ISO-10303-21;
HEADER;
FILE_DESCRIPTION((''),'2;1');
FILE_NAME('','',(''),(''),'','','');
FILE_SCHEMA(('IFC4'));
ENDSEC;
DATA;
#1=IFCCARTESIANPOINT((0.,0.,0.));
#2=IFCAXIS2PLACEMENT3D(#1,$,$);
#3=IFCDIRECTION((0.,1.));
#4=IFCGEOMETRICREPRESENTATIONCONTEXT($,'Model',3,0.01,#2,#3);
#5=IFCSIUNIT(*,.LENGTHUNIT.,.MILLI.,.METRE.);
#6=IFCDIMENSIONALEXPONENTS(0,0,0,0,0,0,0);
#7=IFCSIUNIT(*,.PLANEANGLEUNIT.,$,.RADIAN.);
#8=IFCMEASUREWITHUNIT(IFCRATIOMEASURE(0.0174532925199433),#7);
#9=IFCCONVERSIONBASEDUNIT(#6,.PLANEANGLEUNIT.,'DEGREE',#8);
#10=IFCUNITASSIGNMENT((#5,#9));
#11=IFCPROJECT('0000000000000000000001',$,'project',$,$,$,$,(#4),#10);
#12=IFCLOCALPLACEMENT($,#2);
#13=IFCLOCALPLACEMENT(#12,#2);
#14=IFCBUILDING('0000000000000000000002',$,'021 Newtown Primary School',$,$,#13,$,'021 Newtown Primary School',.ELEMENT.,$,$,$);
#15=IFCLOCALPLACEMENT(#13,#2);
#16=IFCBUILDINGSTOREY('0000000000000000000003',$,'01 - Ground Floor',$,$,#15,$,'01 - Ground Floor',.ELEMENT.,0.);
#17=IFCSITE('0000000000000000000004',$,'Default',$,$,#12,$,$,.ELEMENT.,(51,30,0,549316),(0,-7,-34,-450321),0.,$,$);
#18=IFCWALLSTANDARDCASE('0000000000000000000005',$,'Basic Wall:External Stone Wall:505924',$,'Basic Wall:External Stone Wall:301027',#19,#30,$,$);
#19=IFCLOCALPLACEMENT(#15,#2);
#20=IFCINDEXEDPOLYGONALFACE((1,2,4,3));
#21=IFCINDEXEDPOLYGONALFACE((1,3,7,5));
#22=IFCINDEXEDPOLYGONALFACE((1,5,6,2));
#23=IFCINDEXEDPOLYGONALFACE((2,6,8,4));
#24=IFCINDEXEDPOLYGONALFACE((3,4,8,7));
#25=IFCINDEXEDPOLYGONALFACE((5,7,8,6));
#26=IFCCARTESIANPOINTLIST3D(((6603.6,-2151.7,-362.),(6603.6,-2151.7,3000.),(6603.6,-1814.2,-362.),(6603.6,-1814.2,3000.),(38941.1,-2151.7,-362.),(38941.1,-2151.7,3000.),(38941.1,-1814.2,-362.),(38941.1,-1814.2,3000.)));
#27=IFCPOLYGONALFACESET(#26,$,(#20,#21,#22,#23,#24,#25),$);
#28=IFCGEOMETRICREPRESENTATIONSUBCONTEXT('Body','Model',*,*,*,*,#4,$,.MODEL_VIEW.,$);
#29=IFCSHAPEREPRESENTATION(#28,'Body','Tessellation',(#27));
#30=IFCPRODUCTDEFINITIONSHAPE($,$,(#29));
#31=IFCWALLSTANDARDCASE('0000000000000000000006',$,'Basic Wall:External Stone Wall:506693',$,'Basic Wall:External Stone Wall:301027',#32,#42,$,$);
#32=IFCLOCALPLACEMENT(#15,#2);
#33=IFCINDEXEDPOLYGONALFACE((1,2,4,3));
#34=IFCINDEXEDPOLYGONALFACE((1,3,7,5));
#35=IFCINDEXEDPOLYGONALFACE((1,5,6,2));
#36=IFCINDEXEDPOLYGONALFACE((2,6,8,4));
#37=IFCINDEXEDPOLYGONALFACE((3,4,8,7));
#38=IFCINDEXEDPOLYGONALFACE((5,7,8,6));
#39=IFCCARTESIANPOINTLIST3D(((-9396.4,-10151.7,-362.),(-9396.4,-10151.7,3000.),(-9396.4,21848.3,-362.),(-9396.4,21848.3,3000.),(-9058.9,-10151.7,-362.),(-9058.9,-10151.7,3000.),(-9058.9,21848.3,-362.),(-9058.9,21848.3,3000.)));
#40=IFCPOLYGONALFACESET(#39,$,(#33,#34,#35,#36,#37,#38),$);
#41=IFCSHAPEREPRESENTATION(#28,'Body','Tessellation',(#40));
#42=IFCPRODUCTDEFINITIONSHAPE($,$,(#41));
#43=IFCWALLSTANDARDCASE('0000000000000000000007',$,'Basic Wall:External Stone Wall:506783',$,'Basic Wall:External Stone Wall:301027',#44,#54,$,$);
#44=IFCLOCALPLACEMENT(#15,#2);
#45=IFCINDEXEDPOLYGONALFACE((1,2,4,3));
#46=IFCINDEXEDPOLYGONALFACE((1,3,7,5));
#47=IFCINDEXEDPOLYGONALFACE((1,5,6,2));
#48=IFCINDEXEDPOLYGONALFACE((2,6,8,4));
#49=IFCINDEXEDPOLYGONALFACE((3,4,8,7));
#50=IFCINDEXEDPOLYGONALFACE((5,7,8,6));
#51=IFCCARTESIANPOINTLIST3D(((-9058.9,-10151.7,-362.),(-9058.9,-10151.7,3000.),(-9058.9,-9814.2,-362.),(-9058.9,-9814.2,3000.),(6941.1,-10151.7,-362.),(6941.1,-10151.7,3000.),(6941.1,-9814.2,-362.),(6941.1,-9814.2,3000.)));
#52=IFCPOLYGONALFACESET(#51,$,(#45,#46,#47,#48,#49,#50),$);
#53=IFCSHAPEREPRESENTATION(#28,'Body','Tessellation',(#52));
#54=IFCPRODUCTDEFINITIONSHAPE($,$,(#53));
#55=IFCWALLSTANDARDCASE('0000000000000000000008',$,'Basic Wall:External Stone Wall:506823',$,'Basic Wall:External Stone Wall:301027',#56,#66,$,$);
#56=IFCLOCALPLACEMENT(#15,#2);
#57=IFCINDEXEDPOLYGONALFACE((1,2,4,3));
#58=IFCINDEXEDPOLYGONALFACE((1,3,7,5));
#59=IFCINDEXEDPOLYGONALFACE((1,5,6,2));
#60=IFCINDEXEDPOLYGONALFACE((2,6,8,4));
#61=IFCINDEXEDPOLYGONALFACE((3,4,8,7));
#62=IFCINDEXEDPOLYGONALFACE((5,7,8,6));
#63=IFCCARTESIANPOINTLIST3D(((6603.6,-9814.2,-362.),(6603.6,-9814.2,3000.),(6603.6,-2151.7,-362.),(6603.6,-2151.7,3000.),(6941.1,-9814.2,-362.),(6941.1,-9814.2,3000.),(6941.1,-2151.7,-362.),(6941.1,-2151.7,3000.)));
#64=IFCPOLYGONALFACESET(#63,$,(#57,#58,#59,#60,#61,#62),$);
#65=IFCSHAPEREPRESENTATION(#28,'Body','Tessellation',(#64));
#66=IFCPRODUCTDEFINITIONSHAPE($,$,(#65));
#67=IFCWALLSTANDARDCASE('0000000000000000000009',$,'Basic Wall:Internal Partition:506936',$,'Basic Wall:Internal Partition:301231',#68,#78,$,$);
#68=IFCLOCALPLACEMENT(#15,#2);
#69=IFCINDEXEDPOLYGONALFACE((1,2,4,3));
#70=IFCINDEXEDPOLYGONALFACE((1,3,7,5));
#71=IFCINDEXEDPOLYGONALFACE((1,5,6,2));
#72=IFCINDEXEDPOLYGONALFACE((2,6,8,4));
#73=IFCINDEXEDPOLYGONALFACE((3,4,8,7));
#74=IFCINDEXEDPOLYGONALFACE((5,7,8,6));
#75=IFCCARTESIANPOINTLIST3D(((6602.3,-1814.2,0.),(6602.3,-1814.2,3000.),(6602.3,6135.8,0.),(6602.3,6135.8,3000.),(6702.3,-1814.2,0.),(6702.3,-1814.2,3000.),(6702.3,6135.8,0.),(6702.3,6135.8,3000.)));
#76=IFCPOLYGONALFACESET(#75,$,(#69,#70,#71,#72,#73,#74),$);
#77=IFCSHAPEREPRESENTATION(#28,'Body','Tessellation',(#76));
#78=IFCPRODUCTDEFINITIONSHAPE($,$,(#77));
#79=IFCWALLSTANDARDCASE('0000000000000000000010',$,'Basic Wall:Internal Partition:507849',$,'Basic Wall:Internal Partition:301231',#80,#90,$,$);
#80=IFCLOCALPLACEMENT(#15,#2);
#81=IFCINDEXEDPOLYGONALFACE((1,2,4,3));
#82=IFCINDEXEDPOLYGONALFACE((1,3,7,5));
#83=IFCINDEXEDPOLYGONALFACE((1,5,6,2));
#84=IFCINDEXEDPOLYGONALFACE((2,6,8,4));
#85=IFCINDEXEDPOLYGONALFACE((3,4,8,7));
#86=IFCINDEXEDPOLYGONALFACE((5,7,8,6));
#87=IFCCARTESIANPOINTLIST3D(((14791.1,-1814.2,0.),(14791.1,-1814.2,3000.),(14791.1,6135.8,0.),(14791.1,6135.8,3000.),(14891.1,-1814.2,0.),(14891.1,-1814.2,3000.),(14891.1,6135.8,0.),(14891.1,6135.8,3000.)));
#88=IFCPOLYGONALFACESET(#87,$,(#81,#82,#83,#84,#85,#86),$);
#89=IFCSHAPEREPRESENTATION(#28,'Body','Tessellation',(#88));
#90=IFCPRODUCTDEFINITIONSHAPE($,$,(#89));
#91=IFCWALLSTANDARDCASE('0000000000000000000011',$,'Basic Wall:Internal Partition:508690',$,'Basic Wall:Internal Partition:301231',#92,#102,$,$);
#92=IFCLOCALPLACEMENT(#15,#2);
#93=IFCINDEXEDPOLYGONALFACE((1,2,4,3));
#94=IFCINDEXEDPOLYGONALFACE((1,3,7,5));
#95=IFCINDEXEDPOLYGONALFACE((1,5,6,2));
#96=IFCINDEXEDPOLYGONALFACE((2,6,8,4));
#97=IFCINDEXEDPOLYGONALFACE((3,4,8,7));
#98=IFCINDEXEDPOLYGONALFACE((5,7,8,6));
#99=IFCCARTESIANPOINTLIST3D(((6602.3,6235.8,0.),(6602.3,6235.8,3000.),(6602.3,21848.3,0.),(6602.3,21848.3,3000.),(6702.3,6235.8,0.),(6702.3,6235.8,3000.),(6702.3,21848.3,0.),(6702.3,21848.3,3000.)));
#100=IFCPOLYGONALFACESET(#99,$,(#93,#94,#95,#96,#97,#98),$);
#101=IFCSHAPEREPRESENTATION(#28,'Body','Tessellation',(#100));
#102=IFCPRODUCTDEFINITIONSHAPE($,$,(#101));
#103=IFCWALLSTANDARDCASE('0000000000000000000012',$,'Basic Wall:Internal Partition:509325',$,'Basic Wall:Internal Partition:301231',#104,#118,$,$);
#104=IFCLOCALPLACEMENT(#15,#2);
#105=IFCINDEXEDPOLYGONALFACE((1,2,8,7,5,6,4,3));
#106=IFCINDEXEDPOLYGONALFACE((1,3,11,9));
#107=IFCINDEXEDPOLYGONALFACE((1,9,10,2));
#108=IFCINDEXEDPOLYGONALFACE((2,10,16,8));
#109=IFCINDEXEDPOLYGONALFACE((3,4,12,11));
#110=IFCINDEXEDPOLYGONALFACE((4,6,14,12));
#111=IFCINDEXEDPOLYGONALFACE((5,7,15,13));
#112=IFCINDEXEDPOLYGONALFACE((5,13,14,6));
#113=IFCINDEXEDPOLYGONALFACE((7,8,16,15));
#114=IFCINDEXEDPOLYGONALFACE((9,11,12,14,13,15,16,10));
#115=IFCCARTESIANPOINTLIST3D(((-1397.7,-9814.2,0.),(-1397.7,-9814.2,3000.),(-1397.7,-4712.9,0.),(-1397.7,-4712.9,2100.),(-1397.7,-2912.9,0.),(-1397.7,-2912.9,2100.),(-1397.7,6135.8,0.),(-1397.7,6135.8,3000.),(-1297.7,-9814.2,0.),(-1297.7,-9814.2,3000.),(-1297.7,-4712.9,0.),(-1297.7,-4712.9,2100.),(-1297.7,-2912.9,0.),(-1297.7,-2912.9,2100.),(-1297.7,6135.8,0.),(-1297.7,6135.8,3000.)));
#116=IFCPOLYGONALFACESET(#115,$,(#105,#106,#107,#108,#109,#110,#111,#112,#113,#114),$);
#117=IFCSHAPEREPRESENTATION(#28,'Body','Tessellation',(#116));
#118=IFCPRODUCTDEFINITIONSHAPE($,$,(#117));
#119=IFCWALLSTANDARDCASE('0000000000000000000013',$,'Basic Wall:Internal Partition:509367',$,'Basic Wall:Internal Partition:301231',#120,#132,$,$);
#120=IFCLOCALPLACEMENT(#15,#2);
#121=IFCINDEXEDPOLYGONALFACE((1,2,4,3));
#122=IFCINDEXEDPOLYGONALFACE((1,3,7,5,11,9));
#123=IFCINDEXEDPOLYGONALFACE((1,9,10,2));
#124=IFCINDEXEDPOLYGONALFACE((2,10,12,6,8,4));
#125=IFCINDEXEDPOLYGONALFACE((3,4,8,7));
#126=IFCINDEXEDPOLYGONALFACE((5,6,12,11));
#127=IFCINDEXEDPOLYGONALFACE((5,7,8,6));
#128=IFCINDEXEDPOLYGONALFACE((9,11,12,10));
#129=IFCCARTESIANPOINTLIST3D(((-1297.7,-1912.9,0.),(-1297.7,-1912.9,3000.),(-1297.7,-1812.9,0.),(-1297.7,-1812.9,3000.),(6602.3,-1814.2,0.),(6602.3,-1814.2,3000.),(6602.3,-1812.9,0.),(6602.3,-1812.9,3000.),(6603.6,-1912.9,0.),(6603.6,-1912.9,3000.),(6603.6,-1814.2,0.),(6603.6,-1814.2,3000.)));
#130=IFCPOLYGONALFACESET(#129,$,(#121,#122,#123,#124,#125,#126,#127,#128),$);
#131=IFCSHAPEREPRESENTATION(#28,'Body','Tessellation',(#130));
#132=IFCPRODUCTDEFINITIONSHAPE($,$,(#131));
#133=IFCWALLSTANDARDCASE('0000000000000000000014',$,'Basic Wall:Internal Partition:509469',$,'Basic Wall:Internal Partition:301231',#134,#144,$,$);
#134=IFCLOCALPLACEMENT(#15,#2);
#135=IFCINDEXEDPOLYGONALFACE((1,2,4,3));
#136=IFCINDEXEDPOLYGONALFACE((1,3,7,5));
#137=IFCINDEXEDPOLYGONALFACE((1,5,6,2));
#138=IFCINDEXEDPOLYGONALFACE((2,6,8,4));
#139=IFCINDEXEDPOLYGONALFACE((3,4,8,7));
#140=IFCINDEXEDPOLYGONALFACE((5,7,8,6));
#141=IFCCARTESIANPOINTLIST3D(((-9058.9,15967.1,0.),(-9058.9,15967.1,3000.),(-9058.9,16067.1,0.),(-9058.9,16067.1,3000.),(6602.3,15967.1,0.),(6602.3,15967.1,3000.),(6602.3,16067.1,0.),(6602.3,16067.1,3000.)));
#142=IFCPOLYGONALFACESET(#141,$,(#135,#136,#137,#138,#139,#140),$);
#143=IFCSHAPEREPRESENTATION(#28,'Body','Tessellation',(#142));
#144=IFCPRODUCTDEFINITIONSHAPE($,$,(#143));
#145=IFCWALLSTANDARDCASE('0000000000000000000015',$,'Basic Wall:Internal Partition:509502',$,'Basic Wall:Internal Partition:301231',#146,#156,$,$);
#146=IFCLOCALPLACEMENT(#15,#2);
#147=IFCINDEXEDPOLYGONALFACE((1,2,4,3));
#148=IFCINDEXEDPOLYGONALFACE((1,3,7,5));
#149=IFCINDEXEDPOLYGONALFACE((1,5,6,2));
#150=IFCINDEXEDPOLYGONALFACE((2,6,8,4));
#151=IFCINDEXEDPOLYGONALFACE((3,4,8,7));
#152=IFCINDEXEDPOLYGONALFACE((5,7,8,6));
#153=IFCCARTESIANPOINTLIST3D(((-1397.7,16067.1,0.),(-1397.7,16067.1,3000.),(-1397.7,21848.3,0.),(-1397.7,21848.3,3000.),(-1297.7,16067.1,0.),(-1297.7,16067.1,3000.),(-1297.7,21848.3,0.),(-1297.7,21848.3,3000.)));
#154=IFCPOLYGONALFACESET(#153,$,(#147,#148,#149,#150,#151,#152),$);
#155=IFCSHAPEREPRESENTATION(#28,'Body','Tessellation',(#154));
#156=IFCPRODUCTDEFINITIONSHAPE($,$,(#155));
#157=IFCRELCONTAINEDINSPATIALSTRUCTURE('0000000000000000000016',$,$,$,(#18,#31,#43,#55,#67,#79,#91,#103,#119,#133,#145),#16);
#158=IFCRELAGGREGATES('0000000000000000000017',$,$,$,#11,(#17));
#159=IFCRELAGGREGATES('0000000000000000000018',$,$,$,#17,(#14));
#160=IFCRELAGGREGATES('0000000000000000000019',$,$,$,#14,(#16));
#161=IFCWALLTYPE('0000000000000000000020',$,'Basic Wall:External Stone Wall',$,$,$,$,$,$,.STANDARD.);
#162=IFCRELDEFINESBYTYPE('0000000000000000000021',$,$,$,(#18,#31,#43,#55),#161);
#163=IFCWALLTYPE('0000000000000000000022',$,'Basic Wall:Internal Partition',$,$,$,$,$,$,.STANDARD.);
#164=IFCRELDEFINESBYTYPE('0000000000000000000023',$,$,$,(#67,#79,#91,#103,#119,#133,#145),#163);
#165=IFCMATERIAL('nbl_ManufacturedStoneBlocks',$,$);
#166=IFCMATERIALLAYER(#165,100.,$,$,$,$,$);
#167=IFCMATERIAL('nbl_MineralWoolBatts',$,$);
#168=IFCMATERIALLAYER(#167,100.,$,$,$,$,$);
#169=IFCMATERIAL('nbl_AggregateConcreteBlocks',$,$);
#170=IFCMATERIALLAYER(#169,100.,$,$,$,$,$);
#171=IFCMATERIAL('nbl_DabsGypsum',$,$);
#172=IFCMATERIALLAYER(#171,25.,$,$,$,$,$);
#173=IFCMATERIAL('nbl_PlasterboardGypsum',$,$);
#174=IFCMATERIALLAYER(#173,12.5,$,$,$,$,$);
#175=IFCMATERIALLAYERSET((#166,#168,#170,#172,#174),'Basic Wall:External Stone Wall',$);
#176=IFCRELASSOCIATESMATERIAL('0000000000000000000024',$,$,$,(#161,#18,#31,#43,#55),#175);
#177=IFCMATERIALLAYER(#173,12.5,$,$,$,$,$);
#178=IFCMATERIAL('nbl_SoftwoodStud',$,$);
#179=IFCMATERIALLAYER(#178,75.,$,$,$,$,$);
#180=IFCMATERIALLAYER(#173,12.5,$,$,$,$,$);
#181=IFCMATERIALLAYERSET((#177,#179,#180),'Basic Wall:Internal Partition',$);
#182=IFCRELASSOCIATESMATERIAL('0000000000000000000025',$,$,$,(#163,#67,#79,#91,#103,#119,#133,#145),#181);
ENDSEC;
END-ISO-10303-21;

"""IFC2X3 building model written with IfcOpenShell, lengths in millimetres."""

from ifc_helpers import new_model, entity, si_unit, converted_unit, direction, frame, frame_2d, origin, place, context, subcontext, project, spatial, polyline, rectangle, outline, extrude, material, layer, layer_set, layer_usage, type_object, element, save


model = new_model("IFC2X3")

# Units and contexts
model_context = context("Model", 3, precision=0.01, world=origin(), true_north=direction((0.0, 1.0)))
body_context = subcontext(model_context, "Body", "Model", "MODEL_VIEW")
ifc_project = project(units=[si_unit("LENGTHUNIT", "METRE", prefix="MILLI"), converted_unit("PLANEANGLEUNIT", "DEGREE", entity("IfcRatioMeasure", 0.0174532925199433), si_unit("PLANEANGLEUNIT", "RADIAN"), dimensions=[0, 0, 0, 0, 0, 0, 0])], contexts=[model_context])

# Site, building, storey
site_placement = place(None, origin())
site = spatial("IfcSite", under=ifc_project, at=site_placement, Name="Default", CompositionType="ELEMENT", RefLatitude=(51, 30, 0, 549316), RefLongitude=(0, -7, -34, -450321), RefElevation=0.0)
building_placement = place(site_placement, origin())
building = spatial("IfcBuilding", under=site, at=building_placement, Name="021 Newtown Primary School", LongName="021 Newtown Primary School", CompositionType="ELEMENT")
storey_placement = place(building_placement, origin())
storey = spatial("IfcBuildingStorey", under=building, at=storey_placement, Name="01 - Ground Floor", LongName="01 - Ground Floor", CompositionType="ELEMENT", Elevation=0.0)

# Walls
ifc_material_1 = material(Name="nbl_ManufacturedStoneBlocks")
ifc_layer_1 = layer(ifc_material_1, 100.0)
ifc_material_2 = material(Name="nbl_MineralWoolBatts")
ifc_layer_2 = layer(ifc_material_2, 100.0)
ifc_material_3 = material(Name="nbl_AggregateConcreteBlocks")
ifc_layer_3 = layer(ifc_material_3, 100.0)
ifc_material_4 = material(Name="nbl_DabsGypsum")
ifc_layer_4 = layer(ifc_material_4, 25.0)
ifc_material_5 = material(Name="nbl_PlasterboardGypsum")
ifc_layer_5 = layer(ifc_material_5, 12.5)
ifc_layer_set_1 = layer_set([ifc_layer_1, ifc_layer_2, ifc_layer_3, ifc_layer_4, ifc_layer_5], Name="Basic Wall:External Stone Wall")
ifc_layer_usage_1 = layer_usage(ifc_layer_set_1, "AXIS2", "NEGATIVE", 168.8)
wall_type_1 = type_object("IfcWallType", Name="Basic Wall:External Stone Wall", PredefinedType="STANDARD", material=ifc_layer_set_1)
wall_1_placement = place(storey_placement, frame((6603.6, -1982.9, -362.0)))
element("IfcWallStandardCase", 1, at=wall_1_placement, inside=storey, type_object=wall_type_1, material=ifc_layer_usage_1, Name="Basic Wall:External Stone Wall:505924", ObjectType="Basic Wall:External Stone Wall:301027", context=body_context, shape_type="SweptSolid", body=[
    extrude(rectangle(XDim=32337.5, YDim=337.5, at=frame_2d((16168.8, 0.0), x_axis=(-1.0, 0.0))), origin(), (0.0, 0.0, 1.0), 3362.0),
])
ifc_layer_usage_2 = layer_usage(ifc_layer_set_1, "AXIS2", "NEGATIVE", 168.8)
wall_2_placement = place(storey_placement, frame((-9227.7, 21848.3, -362.0), z_axis=(0.0, 0.0, 1.0), x_axis=(0.0, -1.0, 0.0)))
element("IfcWallStandardCase", 2, at=wall_2_placement, inside=storey, type_object=wall_type_1, material=ifc_layer_usage_2, Name="Basic Wall:External Stone Wall:506693", ObjectType="Basic Wall:External Stone Wall:301027", context=body_context, shape_type="SweptSolid", body=[
    extrude(rectangle(XDim=32000.0, YDim=337.5, at=frame_2d((16000.0, 0.0), x_axis=(-1.0, 0.0))), origin(), (0.0, 0.0, 1.0), 3362.0),
])
ifc_layer_usage_3 = layer_usage(ifc_layer_set_1, "AXIS2", "NEGATIVE", 168.8)
wall_3_placement = place(storey_placement, frame((-9058.9, -9982.9, -362.0)))
element("IfcWallStandardCase", 3, at=wall_3_placement, inside=storey, type_object=wall_type_1, material=ifc_layer_usage_3, Name="Basic Wall:External Stone Wall:506783", ObjectType="Basic Wall:External Stone Wall:301027", context=body_context, shape_type="SweptSolid", body=[
    extrude(rectangle(XDim=16000.0, YDim=337.5, at=frame_2d((8000.0, 0.0), x_axis=(-1.0, 0.0))), origin(), (0.0, 0.0, 1.0), 3362.0),
])
ifc_layer_usage_4 = layer_usage(ifc_layer_set_1, "AXIS2", "NEGATIVE", 168.8)
wall_4_placement = place(storey_placement, frame((6772.3, -9814.2, -362.0), z_axis=(0.0, 0.0, 1.0), x_axis=(0.0, 1.0, 0.0)))
element("IfcWallStandardCase", 4, at=wall_4_placement, inside=storey, type_object=wall_type_1, material=ifc_layer_usage_4, Name="Basic Wall:External Stone Wall:506823", ObjectType="Basic Wall:External Stone Wall:301027", context=body_context, shape_type="SweptSolid", body=[
    extrude(rectangle(XDim=7662.5, YDim=337.5, at=frame_2d((3831.3, 0.0), x_axis=(-1.0, 0.0))), origin(), (0.0, 0.0, 1.0), 3362.0),
])
ifc_layer_6 = layer(ifc_material_5, 12.5)
ifc_material_6 = material(Name="nbl_SoftwoodStud")
ifc_layer_7 = layer(ifc_material_6, 75.0)
ifc_layer_8 = layer(ifc_material_5, 12.5)
ifc_layer_set_2 = layer_set([ifc_layer_6, ifc_layer_7, ifc_layer_8], Name="Basic Wall:Internal Partition")
ifc_layer_usage_5 = layer_usage(ifc_layer_set_2, "AXIS2", "NEGATIVE", 50.0)
wall_type_2 = type_object("IfcWallType", Name="Basic Wall:Internal Partition", PredefinedType="STANDARD", material=ifc_layer_set_2)
wall_5_placement = place(storey_placement, frame((6652.3, -1814.2, 0.0), z_axis=(0.0, 0.0, 1.0), x_axis=(0.0, 1.0, 0.0)))
element("IfcWallStandardCase", 5, at=wall_5_placement, inside=storey, type_object=wall_type_2, material=ifc_layer_usage_5, Name="Basic Wall:Internal Partition:506936", ObjectType="Basic Wall:Internal Partition:301231", context=body_context, shape_type="SweptSolid", body=[
    extrude(rectangle(XDim=7950.0, YDim=100.0, at=frame_2d((3975.0, 0.0), x_axis=(-1.0, 0.0))), origin(), (0.0, 0.0, 1.0), 3000.0),
])
ifc_layer_usage_6 = layer_usage(ifc_layer_set_2, "AXIS2", "NEGATIVE", 50.0)
wall_6_placement = place(storey_placement, frame((14841.1, 6135.8, 0.0), z_axis=(0.0, 0.0, 1.0), x_axis=(0.0, -1.0, 0.0)))
element("IfcWallStandardCase", 6, at=wall_6_placement, inside=storey, type_object=wall_type_2, material=ifc_layer_usage_6, Name="Basic Wall:Internal Partition:507849", ObjectType="Basic Wall:Internal Partition:301231", context=body_context, shape_type="SweptSolid", body=[
    extrude(rectangle(XDim=7950.0, YDim=100.0, at=frame_2d((3975.0, 0.0), x_axis=(-1.0, 0.0))), origin(), (0.0, 0.0, 1.0), 3000.0),
])
ifc_layer_usage_7 = layer_usage(ifc_layer_set_2, "AXIS2", "NEGATIVE", 50.0)
wall_7_placement = place(storey_placement, frame((6652.3, 21848.3, 0.0), z_axis=(0.0, 0.0, 1.0), x_axis=(0.0, -1.0, 0.0)))
element("IfcWallStandardCase", 7, at=wall_7_placement, inside=storey, type_object=wall_type_2, material=ifc_layer_usage_7, Name="Basic Wall:Internal Partition:508690", ObjectType="Basic Wall:Internal Partition:301231", context=body_context, shape_type="SweptSolid", body=[
    extrude(rectangle(XDim=15612.5, YDim=100.0, at=frame_2d((7806.2, 0.0), x_axis=(-1.0, 0.0))), origin(), (0.0, 0.0, 1.0), 3000.0),
])

# Wall, opening
ifc_layer_usage_8 = layer_usage(ifc_layer_set_2, "AXIS2", "NEGATIVE", 50.0)
wall_8_placement = place(storey_placement, frame((-1347.7, 6135.8, 0.0), z_axis=(0.0, 0.0, 1.0), x_axis=(0.0, -1.0, 0.0)))
wall_8 = element("IfcWallStandardCase", 8, at=wall_8_placement, inside=storey, type_object=wall_type_2, material=ifc_layer_usage_8, Name="Basic Wall:Internal Partition:509325", ObjectType="Basic Wall:Internal Partition:301231", context=body_context, shape_type="SweptSolid", body=[
    extrude(rectangle(XDim=15950.0, YDim=100.0, at=frame_2d((7975.0, 0.0), x_axis=(-1.0, 0.0))), origin(), (0.0, 0.0, 1.0), 3000.0),
])
opening_1_placement = place(wall_8_placement, origin())
element("IfcOpeningElement", 9, at=opening_1_placement, cuts=wall_8, ObjectType="Opening", context=body_context, shape_type="SweptSolid", body=[
    extrude(rectangle(XDim=2100.0, YDim=1800.0, at=frame_2d((0.0, 0.0), x_axis=(0.0, 1.0))), frame((9948.8, -1574.0, 1050.0), z_axis=(0.0, 1.0, 0.0), x_axis=(-1.0, 0.0, 0.0)), (0.0, 0.0, 1.0), 3048.0),
])

# Walls
ifc_layer_usage_9 = layer_usage(ifc_layer_set_2, "AXIS2", "NEGATIVE", 50.0)
wall_9_placement = place(storey_placement, frame((6603.6, -1862.9, 0.0), z_axis=(0.0, 0.0, 1.0), x_axis=(-1.0, 0.0, 0.0)))
element("IfcWallStandardCase", 10, at=wall_9_placement, inside=storey, type_object=wall_type_2, material=ifc_layer_usage_9, Name="Basic Wall:Internal Partition:509367", ObjectType="Basic Wall:Internal Partition:301231", context=body_context, shape_type="SweptSolid", body=[
    extrude(outline(polyline([(7901.2, -50.0), (7901.2, 50.0), (0.0, 50.0), (0.0, -48.8), (1.2, -48.8), (1.2, -50.0), (7901.2, -50.0)])), origin(), (0.0, 0.0, 1.0), 3000.0),
])
ifc_layer_usage_10 = layer_usage(ifc_layer_set_2, "AXIS2", "NEGATIVE", 50.0)
wall_10_placement = place(storey_placement, frame((6602.3, 16017.1, 0.0), z_axis=(0.0, 0.0, 1.0), x_axis=(-1.0, 0.0, 0.0)))
element("IfcWallStandardCase", 11, at=wall_10_placement, inside=storey, type_object=wall_type_2, material=ifc_layer_usage_10, Name="Basic Wall:Internal Partition:509469", ObjectType="Basic Wall:Internal Partition:301231", context=body_context, shape_type="SweptSolid", body=[
    extrude(rectangle(XDim=15661.2, YDim=100.0, at=frame_2d((7830.6, 0.0), x_axis=(-1.0, 0.0))), origin(), (0.0, 0.0, 1.0), 3000.0),
])
ifc_layer_usage_11 = layer_usage(ifc_layer_set_2, "AXIS2", "NEGATIVE", 50.0)
wall_11_placement = place(storey_placement, frame((-1347.7, 21848.3, 0.0), z_axis=(0.0, 0.0, 1.0), x_axis=(0.0, -1.0, 0.0)))
element("IfcWallStandardCase", 12, at=wall_11_placement, inside=storey, type_object=wall_type_2, material=ifc_layer_usage_11, Name="Basic Wall:Internal Partition:509502", ObjectType="Basic Wall:Internal Partition:301231", context=body_context, shape_type="SweptSolid", body=[
    extrude(rectangle(XDim=5781.2, YDim=100.0, at=frame_2d((2890.6, 0.0), x_axis=(-1.0, 0.0))), origin(), (0.0, 0.0, 1.0), 3000.0),
])

save(model, "model.ifc")
